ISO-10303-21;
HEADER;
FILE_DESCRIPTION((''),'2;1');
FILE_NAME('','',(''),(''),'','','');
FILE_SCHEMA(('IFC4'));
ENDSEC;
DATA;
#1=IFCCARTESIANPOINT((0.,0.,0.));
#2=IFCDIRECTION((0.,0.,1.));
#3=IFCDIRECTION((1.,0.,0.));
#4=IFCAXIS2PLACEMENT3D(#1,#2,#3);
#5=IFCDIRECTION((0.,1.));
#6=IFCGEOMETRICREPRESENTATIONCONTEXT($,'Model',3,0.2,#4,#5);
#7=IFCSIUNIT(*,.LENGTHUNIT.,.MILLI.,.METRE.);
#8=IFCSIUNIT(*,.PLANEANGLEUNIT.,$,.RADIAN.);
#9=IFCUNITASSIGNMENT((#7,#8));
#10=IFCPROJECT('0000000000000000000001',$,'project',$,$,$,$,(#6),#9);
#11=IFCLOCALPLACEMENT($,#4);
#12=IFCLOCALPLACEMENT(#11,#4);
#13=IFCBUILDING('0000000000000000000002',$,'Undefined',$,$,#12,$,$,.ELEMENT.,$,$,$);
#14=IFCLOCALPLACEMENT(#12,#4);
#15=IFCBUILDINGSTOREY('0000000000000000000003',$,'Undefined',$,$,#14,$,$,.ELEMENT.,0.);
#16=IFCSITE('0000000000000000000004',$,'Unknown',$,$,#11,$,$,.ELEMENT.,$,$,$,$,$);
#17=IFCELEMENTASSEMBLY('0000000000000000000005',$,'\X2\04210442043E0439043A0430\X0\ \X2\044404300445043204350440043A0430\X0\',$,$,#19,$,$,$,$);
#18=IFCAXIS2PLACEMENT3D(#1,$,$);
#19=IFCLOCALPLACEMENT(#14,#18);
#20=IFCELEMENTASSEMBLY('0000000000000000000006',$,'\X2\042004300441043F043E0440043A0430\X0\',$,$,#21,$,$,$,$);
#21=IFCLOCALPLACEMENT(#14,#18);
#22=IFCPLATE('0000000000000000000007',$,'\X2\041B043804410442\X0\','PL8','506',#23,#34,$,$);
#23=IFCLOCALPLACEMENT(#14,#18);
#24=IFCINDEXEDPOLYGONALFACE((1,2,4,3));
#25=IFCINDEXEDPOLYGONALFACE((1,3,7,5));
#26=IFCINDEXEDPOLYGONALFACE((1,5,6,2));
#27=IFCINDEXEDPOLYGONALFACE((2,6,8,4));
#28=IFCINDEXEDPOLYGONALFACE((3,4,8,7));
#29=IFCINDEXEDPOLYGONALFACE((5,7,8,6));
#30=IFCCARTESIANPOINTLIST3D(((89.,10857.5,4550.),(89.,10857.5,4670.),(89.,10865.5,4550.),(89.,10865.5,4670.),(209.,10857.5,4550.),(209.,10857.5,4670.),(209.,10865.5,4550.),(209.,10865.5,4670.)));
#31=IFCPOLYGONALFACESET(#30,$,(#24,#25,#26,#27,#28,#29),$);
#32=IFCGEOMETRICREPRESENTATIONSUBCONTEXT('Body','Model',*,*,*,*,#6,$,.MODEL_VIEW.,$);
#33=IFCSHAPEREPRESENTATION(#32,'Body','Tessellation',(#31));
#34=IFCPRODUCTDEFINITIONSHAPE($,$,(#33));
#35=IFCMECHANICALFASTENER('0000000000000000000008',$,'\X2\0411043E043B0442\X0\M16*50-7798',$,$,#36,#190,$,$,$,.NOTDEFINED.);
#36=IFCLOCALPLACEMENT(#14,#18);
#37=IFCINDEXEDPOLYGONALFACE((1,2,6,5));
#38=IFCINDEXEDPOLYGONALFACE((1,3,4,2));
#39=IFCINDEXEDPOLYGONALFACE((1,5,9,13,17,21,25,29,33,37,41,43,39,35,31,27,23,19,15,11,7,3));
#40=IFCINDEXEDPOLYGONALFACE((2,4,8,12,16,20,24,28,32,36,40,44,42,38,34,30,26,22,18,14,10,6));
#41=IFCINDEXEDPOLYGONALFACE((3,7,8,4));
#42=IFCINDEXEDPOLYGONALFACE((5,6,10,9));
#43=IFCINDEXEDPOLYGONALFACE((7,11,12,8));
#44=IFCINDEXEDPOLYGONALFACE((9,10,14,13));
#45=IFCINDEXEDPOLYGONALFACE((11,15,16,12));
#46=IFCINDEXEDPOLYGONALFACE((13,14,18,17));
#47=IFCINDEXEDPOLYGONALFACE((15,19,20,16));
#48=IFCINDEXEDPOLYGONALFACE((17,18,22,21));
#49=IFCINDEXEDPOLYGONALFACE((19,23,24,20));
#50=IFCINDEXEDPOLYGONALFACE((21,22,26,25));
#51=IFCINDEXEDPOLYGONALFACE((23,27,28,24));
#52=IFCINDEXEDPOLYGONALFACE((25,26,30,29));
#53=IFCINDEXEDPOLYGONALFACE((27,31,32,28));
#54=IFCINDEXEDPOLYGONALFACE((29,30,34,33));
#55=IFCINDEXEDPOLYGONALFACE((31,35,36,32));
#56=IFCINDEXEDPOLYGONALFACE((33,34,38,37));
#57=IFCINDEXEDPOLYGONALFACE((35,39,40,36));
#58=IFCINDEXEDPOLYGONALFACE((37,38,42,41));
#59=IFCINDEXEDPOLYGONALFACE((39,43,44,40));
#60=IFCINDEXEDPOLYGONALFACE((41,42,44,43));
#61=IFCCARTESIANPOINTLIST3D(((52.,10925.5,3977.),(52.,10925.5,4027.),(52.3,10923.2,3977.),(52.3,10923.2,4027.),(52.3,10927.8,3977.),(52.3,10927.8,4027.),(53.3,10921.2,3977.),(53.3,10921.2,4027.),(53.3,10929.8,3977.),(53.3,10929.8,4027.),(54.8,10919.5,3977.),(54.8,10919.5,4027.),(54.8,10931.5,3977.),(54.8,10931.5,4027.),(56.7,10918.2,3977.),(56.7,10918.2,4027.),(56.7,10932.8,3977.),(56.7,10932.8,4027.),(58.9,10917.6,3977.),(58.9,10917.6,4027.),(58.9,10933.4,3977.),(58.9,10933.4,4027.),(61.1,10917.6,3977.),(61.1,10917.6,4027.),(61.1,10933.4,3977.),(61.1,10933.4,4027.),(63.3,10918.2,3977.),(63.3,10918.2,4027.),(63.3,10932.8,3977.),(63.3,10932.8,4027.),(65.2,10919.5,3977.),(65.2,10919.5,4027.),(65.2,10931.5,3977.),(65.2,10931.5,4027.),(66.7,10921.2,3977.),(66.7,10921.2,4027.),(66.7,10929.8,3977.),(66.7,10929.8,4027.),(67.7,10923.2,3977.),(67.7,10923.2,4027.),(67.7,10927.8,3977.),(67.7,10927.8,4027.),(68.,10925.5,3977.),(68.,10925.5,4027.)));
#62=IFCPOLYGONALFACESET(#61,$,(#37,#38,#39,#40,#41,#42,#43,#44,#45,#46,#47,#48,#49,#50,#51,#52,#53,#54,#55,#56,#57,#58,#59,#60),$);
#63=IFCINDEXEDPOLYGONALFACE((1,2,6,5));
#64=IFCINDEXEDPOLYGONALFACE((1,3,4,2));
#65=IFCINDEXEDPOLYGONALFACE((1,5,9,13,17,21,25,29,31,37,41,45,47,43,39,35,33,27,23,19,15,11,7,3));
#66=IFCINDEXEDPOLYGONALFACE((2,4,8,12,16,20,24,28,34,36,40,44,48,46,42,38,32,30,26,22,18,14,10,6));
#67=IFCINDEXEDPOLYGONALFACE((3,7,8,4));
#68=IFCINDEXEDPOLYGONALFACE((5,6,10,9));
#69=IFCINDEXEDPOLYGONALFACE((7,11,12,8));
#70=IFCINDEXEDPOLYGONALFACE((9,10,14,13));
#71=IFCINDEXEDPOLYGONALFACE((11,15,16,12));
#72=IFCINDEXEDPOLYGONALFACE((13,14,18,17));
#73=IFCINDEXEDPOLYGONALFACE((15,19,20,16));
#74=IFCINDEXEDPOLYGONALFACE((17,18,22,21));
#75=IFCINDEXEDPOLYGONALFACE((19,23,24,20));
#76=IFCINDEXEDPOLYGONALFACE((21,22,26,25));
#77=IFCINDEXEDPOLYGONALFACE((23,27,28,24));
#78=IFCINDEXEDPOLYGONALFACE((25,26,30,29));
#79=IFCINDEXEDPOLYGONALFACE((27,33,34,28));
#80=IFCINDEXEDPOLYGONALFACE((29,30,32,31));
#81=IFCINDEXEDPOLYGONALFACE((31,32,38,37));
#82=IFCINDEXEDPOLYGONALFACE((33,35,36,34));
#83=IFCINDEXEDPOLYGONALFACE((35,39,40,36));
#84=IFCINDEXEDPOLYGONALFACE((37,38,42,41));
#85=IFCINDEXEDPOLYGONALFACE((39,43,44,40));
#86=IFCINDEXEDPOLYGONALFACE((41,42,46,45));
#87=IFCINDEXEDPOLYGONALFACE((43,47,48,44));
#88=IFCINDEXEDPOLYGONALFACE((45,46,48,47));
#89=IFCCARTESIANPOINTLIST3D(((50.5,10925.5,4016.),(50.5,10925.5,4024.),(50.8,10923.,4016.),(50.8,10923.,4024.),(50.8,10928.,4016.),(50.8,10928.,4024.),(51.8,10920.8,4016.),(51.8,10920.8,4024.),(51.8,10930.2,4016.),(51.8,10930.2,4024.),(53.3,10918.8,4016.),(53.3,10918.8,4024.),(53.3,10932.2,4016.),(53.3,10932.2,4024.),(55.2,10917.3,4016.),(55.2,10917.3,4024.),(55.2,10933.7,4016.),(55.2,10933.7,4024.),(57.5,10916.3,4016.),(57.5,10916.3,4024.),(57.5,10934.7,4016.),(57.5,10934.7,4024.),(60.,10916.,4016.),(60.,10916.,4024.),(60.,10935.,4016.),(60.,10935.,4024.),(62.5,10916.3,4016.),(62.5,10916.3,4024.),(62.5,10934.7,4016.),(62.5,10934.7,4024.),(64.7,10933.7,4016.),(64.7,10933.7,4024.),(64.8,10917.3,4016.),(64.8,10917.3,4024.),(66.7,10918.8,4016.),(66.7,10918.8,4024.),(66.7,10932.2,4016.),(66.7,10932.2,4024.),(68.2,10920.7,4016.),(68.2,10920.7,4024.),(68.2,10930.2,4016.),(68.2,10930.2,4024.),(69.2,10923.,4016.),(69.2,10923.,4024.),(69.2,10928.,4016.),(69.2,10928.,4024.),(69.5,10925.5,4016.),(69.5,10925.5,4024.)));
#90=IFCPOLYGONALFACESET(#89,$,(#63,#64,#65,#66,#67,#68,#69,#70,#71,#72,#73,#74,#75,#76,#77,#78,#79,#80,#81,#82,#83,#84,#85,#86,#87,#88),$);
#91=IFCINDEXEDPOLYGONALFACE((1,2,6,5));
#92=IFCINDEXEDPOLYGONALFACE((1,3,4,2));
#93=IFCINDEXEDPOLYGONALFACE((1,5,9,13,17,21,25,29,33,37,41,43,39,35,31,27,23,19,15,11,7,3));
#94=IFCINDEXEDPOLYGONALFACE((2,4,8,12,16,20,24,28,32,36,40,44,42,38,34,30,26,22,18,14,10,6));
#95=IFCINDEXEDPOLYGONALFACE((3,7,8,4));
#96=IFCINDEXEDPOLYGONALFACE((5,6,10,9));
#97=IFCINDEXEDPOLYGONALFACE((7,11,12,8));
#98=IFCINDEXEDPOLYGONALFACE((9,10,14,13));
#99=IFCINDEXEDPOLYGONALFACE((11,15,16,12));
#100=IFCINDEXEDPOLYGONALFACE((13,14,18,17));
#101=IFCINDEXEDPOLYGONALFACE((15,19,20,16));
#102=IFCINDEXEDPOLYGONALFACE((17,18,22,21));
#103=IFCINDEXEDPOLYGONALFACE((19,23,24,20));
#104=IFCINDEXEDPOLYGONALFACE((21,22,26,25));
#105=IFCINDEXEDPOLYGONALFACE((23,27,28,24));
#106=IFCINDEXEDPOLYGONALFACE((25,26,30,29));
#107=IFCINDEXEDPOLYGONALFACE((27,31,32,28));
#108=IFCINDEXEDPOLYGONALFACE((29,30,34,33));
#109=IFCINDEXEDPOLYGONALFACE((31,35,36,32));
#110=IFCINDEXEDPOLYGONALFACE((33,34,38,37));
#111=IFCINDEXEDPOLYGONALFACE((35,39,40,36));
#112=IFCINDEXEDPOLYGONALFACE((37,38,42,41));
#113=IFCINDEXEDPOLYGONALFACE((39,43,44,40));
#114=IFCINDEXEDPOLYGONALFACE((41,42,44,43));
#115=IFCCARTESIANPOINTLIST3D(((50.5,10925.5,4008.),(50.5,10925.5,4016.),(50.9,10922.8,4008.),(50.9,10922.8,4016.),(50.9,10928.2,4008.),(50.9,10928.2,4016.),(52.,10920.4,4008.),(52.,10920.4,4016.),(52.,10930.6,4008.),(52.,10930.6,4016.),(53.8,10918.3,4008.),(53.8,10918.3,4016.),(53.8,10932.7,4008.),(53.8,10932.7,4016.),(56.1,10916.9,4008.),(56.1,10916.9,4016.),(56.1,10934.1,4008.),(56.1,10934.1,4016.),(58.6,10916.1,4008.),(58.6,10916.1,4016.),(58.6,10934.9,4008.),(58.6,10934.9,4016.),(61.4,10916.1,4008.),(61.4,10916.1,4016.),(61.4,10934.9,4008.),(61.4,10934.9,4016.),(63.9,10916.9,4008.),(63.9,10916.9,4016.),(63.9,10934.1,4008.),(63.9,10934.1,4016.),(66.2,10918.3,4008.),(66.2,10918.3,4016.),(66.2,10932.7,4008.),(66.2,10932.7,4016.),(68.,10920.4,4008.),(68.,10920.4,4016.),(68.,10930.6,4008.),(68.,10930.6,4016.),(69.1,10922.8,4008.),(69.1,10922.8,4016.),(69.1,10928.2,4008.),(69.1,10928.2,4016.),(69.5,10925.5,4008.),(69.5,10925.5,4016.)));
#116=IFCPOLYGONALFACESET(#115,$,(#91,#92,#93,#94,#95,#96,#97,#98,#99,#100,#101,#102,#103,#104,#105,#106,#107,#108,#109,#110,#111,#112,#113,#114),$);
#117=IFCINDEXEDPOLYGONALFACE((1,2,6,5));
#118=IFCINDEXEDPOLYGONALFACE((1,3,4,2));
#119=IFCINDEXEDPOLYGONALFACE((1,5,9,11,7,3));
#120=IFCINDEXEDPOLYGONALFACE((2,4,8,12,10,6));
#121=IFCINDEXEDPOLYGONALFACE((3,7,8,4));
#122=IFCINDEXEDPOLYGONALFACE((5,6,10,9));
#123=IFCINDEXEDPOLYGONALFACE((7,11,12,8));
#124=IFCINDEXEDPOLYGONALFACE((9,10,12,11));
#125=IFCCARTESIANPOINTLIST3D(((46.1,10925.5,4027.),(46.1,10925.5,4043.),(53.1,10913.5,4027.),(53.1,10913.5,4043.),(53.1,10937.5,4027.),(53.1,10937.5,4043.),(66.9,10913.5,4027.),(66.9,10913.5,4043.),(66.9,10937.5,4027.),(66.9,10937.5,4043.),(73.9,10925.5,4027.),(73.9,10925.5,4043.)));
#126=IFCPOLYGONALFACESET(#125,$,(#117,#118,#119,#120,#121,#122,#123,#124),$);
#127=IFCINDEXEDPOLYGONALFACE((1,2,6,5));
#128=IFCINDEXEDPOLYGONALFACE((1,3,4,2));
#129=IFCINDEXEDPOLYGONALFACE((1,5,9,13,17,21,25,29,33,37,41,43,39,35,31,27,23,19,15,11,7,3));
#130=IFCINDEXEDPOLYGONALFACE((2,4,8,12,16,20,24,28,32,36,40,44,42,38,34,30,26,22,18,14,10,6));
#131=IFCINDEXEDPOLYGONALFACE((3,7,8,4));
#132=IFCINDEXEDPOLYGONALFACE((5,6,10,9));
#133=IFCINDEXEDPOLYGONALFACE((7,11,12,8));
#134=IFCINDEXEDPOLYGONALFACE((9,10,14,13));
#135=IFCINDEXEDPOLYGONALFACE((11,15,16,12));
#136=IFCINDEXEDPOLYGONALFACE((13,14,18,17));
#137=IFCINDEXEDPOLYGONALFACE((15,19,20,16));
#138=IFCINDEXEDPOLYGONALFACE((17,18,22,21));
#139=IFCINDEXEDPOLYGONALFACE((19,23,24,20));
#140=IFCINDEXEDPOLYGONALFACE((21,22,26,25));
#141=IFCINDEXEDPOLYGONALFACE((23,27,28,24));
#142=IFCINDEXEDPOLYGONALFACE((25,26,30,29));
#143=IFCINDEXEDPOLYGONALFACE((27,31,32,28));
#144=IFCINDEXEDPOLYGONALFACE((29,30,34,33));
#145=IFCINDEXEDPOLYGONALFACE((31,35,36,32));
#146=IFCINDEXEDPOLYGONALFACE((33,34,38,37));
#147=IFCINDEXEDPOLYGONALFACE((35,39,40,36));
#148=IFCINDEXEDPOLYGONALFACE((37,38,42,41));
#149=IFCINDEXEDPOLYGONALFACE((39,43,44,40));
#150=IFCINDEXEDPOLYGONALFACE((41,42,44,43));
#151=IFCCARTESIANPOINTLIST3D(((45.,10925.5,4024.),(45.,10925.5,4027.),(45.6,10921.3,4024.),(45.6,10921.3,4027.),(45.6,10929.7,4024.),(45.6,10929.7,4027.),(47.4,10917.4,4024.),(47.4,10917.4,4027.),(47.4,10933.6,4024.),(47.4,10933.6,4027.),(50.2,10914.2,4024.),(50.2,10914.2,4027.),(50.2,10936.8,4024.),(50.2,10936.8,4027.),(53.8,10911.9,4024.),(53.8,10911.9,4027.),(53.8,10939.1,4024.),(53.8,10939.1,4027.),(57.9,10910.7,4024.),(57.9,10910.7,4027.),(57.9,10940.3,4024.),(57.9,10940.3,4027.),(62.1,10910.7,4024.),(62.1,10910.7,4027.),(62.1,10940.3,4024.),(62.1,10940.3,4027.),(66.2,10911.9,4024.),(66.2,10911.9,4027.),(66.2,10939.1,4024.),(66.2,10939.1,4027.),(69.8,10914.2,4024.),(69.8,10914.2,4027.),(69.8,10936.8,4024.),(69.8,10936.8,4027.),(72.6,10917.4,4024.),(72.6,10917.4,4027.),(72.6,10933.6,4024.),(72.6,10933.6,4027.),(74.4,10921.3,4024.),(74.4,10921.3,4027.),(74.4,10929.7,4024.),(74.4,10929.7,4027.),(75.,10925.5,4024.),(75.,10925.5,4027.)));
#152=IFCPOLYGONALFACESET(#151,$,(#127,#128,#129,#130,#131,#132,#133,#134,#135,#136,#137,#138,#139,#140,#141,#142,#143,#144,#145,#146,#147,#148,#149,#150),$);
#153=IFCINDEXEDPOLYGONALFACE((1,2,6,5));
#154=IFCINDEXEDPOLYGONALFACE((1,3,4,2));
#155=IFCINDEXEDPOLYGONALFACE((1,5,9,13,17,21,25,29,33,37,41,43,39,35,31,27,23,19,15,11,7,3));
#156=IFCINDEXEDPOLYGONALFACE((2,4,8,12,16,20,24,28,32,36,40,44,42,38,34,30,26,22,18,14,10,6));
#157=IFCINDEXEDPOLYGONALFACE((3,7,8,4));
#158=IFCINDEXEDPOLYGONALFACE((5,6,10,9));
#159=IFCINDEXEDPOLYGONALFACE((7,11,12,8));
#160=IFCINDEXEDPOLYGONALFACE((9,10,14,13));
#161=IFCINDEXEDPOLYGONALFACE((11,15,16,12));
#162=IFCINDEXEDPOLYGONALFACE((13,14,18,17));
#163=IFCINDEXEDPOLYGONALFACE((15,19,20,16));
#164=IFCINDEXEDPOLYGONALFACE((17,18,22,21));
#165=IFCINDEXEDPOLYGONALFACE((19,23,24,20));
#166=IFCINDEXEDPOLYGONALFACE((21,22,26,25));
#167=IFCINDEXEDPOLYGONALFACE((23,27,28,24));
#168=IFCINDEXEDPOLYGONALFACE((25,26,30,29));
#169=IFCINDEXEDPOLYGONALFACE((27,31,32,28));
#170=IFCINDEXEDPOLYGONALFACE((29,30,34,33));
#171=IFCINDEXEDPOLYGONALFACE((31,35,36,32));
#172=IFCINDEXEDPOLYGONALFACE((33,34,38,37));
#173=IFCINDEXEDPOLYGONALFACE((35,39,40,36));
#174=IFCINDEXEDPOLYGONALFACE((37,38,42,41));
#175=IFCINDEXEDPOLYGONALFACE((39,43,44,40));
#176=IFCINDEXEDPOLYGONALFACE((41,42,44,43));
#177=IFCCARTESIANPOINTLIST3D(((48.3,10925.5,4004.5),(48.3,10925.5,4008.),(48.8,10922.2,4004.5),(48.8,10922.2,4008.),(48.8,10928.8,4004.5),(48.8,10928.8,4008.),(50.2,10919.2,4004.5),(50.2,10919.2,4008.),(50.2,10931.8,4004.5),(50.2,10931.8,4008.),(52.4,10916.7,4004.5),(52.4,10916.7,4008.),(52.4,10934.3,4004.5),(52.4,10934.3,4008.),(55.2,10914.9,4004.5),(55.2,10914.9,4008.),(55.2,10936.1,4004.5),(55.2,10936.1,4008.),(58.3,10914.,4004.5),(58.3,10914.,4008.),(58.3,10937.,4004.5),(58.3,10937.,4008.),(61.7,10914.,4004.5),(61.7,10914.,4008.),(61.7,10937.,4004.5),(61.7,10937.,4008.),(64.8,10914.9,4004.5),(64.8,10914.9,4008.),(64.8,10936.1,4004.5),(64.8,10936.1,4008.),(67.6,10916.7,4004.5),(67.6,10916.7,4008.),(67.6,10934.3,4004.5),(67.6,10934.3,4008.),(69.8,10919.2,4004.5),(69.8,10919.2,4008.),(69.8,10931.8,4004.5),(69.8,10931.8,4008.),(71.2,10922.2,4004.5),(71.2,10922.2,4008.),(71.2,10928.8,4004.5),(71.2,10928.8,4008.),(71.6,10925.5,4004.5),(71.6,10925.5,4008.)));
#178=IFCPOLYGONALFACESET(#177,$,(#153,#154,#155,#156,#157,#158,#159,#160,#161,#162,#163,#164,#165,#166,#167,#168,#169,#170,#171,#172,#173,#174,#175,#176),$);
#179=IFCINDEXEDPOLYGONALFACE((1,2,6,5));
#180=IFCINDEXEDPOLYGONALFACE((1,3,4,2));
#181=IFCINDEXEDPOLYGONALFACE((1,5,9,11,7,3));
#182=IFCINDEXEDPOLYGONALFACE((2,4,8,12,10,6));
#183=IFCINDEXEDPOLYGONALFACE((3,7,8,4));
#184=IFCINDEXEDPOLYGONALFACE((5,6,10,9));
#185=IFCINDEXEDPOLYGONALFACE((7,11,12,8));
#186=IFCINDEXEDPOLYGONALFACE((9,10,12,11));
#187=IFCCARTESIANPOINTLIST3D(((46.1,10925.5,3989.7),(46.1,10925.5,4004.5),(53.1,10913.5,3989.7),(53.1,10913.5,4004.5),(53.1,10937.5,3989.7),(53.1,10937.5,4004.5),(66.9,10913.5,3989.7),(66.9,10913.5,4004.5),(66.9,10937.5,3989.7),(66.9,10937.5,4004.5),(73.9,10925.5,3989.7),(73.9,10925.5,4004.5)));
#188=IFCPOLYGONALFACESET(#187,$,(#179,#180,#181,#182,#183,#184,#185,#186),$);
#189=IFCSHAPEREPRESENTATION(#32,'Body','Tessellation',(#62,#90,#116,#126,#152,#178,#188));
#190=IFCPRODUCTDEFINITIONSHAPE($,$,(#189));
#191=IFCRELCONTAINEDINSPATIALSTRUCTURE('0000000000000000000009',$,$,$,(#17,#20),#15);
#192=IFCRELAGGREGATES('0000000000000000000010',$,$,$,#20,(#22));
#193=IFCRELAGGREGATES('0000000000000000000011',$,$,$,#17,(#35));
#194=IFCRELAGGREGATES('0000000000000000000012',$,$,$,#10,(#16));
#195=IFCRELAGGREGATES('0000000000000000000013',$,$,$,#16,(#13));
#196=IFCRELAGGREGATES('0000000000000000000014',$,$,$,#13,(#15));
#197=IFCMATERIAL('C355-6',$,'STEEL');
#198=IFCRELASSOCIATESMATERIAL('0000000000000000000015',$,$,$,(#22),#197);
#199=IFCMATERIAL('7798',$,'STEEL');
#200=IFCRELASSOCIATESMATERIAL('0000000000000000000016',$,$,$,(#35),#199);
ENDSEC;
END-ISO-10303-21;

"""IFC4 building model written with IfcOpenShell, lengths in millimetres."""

from ifc_helpers import new_model, si_unit, direction, frame, origin_with_axes, place, context, subcontext, project, spatial, line, arc, indexed_curve, outline, extrude, source, transform, mapped, material, element, aggregate, save


model = new_model("IFC4")

# Units and contexts
model_context = context("Model", 3, precision=0.2, world=origin_with_axes(), true_north=direction((0.0, 1.0)))
body_context = subcontext(model_context, "Body", "Model", "MODEL_VIEW")
ifc_project = project(units=[si_unit("LENGTHUNIT", "METRE", prefix="MILLI"), si_unit("PLANEANGLEUNIT", "RADIAN")], contexts=[model_context])

# Site, building, storey
site_placement = place(None, origin_with_axes())
site = spatial("IfcSite", under=ifc_project, at=site_placement, Name="Unknown", CompositionType="ELEMENT")
building_placement = place(site_placement, origin_with_axes())
building = spatial("IfcBuilding", under=site, at=building_placement, Name="Undefined", CompositionType="ELEMENT")
storey_placement = place(building_placement, origin_with_axes())
storey = spatial("IfcBuildingStorey", under=building, at=storey_placement, Name="Undefined", CompositionType="ELEMENT", Elevation=0.0)

# Shared definitions
ifc_material_1 = material(Name="C355-6", Category="STEEL")

# Element assemblies, plate
assembly_1_placement = place(storey_placement, frame((149.0, 11000.0, -200.0), z_axis=(0.0, -1.0, 0.0), x_axis=(0.0, 0.0, 1.0)))
assembly_1 = element("IfcElementAssembly", 1, at=assembly_1_placement, inside=storey, Name="Стойка фахверка")
assembly_2_placement = place(storey_placement, frame((149.0, 11000.0, 4610.0), z_axis=(0.0, 0.0, -1.0), x_axis=(0.0, -1.0, 0.0)))
assembly_2 = element("IfcElementAssembly", 2, at=assembly_2_placement, inside=storey, Name="Распорка")
plate_1_placement = place(assembly_2_placement, frame((138.5, 60.0, 60.0), z_axis=(-1.0, 0.0, 0.0), x_axis=(0.0, 0.0, -1.0)))
plate_1 = element("IfcPlate", 3, at=plate_1_placement, material=ifc_material_1, Name="Лист", Description="PL8", ObjectType="506", context=body_context, shape_type="SolidModel", body=[
    extrude(outline(indexed_curve([(0.0, 0.0), (120.0, 0.0), (120.0, 120.0), (0.0, 120.0)], segments=[line(1, 2, 3, 4, 1)])), frame((0.0, 0.0, 4.0), z_axis=(0.0, 0.0, 1.0), x_axis=(1.0, 0.0, 0.0)), (0.0, 0.0, -1.0), 8.0),
])
aggregate(assembly_2, [plate_1])

# Mechanical fastener
ifc_material_2 = material(Name="7798", Category="STEEL")
shared_shape_1 = source(origin_with_axes(), body_context, "Body", "SweptSolid", [
    extrude(outline(indexed_curve([(8.0, 0.0), (0.0, 8.0), (-8.0, 0.0), (0.0, -8.0)], segments=[arc(1, 2, 3), arc(3, 4, 1)])), frame((0.0, 0.0, 7.0), z_axis=(0.0, 0.0, -1.0), x_axis=(0.0, 1.0, 0.0)), (0.0, 0.0, 1.0), 50.0),
    extrude(outline(indexed_curve([(0.0, 9.5), (6.7, 6.7), (9.5, 0.0), (6.7, -6.7), (0.0, -9.5), (-0.9, -9.5), (-9.5, 0.0), (-6.7, 6.7)], segments=[arc(1, 2, 3), arc(3, 4, 5), arc(5, 6, 7), arc(7, 8, 1)])), frame((0.0, 0.0, 4.0), z_axis=(0.0, 0.0, -1.0), x_axis=(0.0, 1.0, 0.0)), (0.0, 0.0, 1.0), 8.0),
    extrude(outline(indexed_curve([(9.5, 0.0), (0.0, 9.5), (-9.5, 0.0), (0.0, -9.5)], segments=[arc(1, 2, 3), arc(3, 4, 1)])), frame((0.0, 0.0, -4.0), z_axis=(0.0, 0.0, -1.0), x_axis=(0.0, 1.0, 0.0)), (0.0, 0.0, 1.0), 8.0),
    extrude(outline(indexed_curve([(13.9, 0.0), (6.9, 12.0), (-6.9, 12.0), (-13.9, 0.0), (-6.9, -12.0), (6.9, -12.0)], segments=[line(1, 2, 3, 4, 5, 6, 1)])), frame((0.0, 0.0, 23.0), z_axis=(0.0, 0.0, -1.0), x_axis=(0.0, 1.0, 0.0)), (0.0, 0.0, 1.0), 16.0),
    extrude(outline(indexed_curve([(15.0, 0.0), (0.0, 15.0), (-15.0, 0.0), (0.0, -15.0)], segments=[arc(1, 2, 3), arc(3, 4, 1)])), frame((0.0, 0.0, 7.0), z_axis=(0.0, 0.0, -1.0), x_axis=(0.0, 1.0, 0.0)), (0.0, 0.0, 1.0), 3.0),
    extrude(outline(indexed_curve([(11.7, 0.0), (0.0, 11.7), (-11.7, 0.0), (0.0, -11.7)], segments=[arc(1, 2, 3), arc(3, 4, 1)])), frame((0.0, 0.0, -12.0), z_axis=(0.0, 0.0, -1.0), x_axis=(0.0, 1.0, 0.0)), (0.0, 0.0, 1.0), 3.5),
    extrude(outline(indexed_curve([(13.9, 0.0), (6.9, 12.0), (-6.9, 12.0), (-13.9, 0.0), (-6.9, -12.0), (6.9, -12.0)], segments=[line(1, 2, 3, 4, 5, 6, 1)])), frame((0.0, 0.0, -15.5), z_axis=(0.0, 0.0, -1.0), x_axis=(0.0, 1.0, 0.0)), (0.0, 0.0, 1.0), 14.8),
])
mechanical_fastener_1_placement = place(assembly_1_placement, frame((4220.0, 89.0, 74.5), z_axis=(1.0, 0.0, 0.0), x_axis=(0.0, 0.0, -1.0)))
mechanical_fastener_1 = element("IfcMechanicalFastener", 4, at=mechanical_fastener_1_placement, material=ifc_material_2, Name="БолтM16*50-7798", PredefinedType="NOTDEFINED", context=body_context, shape_type="MappedRepresentation", body=[
    mapped(shared_shape_1, transform((0.0, 0.0, 0.0))),
])
aggregate(assembly_1, [mechanical_fastener_1])

save(model, "model.ifc")
